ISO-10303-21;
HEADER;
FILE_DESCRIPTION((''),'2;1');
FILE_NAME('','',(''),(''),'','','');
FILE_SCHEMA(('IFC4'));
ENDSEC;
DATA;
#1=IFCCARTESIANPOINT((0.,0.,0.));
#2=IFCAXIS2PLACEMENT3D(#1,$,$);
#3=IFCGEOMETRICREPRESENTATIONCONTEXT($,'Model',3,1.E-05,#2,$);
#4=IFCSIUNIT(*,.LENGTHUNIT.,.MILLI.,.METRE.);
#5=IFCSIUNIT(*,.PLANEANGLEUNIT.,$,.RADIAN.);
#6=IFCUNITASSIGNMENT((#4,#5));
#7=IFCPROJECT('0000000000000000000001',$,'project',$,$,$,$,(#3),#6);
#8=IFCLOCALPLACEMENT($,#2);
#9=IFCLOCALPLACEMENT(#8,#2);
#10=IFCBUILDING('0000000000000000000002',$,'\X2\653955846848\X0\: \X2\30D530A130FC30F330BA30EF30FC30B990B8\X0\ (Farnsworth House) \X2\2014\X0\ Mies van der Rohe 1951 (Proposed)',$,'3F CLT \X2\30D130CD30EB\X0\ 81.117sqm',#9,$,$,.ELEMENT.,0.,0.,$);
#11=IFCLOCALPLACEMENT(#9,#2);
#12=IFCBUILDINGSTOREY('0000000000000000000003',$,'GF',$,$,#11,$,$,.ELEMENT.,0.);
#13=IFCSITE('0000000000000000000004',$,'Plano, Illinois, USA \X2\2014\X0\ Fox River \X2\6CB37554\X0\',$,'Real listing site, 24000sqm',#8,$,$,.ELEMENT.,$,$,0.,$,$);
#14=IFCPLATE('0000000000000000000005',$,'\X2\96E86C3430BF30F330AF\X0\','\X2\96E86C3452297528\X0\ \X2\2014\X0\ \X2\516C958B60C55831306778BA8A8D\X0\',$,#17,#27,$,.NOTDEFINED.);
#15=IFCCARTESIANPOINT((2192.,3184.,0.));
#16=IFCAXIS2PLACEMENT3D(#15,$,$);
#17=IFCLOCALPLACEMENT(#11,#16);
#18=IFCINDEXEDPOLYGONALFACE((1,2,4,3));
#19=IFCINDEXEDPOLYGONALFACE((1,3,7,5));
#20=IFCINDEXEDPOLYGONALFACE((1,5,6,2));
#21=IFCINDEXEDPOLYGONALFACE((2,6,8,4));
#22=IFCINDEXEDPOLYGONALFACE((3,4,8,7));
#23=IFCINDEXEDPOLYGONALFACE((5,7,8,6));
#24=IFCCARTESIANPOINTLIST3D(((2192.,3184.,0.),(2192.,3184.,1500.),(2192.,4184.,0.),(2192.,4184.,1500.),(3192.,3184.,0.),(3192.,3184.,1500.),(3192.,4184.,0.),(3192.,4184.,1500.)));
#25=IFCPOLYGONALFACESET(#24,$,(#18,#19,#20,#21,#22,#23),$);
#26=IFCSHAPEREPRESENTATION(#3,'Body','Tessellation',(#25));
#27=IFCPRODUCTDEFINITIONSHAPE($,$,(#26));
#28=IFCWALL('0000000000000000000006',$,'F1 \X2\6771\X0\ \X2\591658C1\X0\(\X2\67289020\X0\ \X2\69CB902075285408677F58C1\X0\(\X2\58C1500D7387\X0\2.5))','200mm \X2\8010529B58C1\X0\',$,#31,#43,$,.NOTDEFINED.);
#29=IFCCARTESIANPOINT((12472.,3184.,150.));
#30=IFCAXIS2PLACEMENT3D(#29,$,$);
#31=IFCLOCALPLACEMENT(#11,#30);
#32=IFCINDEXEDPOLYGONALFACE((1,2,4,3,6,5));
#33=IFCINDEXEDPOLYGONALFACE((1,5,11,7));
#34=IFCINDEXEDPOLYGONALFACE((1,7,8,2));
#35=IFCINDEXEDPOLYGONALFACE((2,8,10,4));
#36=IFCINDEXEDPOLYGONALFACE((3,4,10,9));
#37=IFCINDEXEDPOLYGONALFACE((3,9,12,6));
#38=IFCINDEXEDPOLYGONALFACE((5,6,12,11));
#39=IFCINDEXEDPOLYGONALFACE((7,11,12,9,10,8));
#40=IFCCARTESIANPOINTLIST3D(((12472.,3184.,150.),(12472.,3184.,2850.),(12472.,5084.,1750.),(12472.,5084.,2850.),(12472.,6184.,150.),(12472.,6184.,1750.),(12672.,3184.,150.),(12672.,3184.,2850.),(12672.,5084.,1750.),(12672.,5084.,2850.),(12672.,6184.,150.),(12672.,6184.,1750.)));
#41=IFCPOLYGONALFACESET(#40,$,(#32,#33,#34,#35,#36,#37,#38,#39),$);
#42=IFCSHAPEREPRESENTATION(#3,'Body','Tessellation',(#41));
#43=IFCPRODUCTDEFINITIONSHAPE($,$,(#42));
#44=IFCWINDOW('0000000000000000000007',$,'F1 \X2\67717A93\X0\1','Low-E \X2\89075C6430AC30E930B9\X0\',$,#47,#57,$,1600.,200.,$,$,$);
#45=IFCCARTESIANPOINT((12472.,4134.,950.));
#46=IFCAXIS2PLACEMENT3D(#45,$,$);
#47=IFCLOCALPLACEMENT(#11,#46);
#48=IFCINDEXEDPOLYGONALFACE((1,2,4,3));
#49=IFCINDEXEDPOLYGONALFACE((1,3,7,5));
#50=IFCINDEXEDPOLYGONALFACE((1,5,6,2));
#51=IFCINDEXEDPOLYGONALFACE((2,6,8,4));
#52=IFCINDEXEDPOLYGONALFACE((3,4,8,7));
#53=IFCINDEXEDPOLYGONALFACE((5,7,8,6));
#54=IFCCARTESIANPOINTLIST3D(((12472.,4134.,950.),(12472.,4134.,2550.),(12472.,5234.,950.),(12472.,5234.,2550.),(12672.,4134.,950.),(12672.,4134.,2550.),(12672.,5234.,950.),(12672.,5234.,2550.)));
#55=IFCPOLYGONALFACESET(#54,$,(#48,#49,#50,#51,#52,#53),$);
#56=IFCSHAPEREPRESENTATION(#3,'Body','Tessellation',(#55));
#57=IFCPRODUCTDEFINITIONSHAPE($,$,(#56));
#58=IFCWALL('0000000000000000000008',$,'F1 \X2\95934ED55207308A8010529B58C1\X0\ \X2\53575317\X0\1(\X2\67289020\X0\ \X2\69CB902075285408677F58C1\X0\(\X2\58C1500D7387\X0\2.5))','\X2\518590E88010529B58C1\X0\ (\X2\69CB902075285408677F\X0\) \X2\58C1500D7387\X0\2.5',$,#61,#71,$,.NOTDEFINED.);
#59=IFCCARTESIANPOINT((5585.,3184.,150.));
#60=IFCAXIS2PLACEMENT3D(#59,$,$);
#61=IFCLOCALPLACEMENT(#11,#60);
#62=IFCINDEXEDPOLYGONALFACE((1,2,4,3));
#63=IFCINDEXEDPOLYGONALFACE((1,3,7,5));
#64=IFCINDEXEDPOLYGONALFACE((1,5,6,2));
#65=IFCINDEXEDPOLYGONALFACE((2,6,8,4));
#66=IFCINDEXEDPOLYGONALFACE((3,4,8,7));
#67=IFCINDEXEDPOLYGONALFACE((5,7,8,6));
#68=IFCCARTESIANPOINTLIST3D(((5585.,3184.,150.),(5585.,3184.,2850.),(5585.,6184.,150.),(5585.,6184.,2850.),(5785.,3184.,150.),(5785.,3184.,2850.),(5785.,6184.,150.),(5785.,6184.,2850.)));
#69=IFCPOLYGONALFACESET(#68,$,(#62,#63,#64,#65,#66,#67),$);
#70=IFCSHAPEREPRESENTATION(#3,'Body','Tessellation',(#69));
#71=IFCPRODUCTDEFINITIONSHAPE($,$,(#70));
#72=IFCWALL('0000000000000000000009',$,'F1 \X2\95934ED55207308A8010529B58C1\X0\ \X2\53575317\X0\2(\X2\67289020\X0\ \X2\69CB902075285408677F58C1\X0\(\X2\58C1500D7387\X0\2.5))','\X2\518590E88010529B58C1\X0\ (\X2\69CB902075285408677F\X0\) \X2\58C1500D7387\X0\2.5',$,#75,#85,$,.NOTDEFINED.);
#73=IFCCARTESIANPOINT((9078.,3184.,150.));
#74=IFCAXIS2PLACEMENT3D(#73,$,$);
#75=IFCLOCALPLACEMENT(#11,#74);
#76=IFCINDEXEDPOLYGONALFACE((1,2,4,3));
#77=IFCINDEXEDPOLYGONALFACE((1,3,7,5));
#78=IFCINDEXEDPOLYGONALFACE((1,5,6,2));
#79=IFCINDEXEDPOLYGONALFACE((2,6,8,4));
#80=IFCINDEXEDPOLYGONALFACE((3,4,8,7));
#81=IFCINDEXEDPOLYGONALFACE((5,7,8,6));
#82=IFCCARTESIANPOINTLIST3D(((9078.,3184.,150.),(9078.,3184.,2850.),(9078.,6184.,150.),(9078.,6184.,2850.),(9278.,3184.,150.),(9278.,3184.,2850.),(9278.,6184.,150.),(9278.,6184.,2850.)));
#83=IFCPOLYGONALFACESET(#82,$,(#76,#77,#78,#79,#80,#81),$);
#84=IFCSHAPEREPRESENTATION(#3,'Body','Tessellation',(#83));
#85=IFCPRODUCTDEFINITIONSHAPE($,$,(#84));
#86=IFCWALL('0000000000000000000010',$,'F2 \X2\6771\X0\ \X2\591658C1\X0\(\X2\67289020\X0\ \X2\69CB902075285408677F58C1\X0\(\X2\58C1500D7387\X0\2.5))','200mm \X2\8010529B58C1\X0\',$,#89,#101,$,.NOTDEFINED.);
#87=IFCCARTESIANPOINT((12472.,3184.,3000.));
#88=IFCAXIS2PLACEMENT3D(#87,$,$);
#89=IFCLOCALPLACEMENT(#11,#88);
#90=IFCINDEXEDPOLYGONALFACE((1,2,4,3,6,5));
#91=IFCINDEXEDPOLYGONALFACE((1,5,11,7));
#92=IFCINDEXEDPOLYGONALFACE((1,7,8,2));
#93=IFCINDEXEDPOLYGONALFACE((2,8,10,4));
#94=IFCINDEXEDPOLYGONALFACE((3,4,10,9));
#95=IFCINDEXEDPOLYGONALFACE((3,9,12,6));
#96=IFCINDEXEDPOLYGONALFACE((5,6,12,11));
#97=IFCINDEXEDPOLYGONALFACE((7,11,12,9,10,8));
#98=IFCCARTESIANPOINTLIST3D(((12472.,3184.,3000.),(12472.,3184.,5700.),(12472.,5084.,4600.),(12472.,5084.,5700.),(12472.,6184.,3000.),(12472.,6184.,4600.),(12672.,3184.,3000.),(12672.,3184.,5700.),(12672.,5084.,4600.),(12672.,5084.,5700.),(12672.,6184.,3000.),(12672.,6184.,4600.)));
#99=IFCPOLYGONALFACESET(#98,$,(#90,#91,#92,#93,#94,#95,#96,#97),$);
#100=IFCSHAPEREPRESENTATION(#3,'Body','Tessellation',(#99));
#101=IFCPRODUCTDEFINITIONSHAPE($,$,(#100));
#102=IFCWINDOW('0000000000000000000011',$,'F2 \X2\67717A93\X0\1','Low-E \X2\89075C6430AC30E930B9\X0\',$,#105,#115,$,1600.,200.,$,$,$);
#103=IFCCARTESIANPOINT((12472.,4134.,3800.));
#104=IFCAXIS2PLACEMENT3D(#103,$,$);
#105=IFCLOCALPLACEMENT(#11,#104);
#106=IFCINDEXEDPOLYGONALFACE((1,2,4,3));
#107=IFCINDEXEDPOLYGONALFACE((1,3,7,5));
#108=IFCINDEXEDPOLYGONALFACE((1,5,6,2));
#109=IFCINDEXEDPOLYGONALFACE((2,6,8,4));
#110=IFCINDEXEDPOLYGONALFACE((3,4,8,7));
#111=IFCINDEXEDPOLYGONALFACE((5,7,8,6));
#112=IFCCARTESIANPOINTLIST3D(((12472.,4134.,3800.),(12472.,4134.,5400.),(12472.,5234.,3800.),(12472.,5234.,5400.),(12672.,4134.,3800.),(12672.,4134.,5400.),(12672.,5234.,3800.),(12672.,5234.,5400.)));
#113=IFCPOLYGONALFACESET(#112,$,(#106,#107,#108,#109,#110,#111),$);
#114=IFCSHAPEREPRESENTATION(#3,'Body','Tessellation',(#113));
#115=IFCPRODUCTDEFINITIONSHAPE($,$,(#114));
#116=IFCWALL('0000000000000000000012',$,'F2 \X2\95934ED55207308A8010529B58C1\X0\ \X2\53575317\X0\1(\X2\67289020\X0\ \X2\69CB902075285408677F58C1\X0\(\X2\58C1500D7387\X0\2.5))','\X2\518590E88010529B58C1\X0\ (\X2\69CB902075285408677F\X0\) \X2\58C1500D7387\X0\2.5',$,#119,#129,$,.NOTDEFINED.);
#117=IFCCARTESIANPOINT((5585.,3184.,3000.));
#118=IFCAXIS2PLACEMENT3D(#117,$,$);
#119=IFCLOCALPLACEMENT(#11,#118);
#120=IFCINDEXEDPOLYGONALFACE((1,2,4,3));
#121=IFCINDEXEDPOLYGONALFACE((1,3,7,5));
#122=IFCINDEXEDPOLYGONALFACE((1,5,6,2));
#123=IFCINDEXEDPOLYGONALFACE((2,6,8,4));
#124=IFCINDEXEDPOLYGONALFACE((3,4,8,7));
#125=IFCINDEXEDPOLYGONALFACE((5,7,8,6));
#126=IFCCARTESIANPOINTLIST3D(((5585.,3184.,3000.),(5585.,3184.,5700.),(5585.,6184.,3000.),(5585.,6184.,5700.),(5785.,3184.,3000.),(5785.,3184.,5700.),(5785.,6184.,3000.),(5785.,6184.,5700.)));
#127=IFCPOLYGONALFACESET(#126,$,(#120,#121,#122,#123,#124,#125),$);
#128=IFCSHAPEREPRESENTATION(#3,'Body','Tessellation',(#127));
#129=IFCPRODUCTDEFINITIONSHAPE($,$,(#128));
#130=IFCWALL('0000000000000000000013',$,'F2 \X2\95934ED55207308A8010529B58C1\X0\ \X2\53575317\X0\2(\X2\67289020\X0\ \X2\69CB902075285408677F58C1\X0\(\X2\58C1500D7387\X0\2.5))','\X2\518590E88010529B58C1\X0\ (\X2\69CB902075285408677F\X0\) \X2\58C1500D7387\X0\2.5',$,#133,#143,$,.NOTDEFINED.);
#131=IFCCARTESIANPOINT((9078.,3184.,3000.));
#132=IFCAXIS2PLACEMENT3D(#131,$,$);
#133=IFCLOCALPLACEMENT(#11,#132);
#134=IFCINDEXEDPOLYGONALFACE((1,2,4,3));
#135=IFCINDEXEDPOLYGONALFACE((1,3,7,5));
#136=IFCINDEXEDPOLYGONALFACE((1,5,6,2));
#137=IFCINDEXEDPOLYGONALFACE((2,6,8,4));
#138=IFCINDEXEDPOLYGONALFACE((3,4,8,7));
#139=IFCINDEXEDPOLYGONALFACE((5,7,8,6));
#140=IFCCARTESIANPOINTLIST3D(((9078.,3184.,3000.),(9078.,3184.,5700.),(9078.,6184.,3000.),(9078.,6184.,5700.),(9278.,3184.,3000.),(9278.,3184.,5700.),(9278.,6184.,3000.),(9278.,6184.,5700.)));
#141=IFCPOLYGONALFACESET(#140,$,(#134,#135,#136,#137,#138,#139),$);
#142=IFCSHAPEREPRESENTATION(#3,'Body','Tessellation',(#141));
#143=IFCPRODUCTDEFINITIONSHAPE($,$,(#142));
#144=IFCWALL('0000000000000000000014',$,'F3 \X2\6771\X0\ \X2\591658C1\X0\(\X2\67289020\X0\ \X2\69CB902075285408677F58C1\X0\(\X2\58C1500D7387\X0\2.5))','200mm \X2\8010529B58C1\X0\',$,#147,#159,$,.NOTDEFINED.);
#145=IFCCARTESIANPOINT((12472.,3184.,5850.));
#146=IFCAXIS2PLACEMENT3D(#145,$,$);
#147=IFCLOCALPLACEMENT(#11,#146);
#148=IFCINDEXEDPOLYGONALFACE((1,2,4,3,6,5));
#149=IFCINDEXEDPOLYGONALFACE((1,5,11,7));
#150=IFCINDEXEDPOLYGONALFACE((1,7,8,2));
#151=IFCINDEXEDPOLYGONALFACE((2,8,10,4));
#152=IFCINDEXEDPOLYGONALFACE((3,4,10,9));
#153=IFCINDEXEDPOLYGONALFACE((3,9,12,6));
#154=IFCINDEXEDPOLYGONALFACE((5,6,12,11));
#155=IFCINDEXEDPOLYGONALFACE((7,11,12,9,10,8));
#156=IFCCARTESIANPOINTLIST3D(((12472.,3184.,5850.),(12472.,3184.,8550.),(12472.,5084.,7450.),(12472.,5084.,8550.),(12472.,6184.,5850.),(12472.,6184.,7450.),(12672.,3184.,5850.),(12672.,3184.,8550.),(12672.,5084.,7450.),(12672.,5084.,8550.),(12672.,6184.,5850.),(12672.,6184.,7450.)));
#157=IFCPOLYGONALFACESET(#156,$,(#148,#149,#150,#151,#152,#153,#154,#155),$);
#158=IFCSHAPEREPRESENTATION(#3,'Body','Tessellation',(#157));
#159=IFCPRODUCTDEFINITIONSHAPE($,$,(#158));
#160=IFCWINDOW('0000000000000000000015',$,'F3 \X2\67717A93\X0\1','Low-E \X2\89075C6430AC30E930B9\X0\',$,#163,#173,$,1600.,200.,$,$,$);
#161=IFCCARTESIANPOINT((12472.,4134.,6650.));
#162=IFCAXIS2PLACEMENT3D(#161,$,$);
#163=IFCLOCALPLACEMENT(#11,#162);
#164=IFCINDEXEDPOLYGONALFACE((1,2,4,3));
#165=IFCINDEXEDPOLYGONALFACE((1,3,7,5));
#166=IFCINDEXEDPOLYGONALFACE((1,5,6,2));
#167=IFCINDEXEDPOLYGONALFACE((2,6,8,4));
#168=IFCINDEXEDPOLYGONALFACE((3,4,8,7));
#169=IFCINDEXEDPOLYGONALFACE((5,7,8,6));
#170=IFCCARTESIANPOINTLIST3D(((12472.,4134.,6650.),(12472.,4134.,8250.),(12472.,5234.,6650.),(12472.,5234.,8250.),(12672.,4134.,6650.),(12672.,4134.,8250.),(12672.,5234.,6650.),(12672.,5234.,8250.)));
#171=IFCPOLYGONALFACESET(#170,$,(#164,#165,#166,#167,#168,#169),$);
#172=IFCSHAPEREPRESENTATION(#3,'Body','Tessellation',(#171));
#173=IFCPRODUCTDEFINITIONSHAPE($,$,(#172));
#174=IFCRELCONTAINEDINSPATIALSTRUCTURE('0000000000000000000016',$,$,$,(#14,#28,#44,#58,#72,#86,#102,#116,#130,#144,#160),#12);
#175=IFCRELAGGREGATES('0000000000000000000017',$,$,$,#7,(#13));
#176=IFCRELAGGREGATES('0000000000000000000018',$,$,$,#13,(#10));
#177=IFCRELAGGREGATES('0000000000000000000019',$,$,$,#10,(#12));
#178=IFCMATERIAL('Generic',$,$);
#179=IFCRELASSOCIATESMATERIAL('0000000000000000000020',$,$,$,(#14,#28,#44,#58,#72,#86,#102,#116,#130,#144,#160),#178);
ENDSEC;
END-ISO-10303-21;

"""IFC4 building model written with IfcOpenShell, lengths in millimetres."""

from ifc_helpers import new_model, si_unit, frame, frame_2d, origin, place, context, project, spatial, rectangle, extrude, material, element, fill, save


model = new_model("IFC4")

# Units and contexts
model_context = context("Model", 3, precision=1e-05, world=origin())
ifc_project = project(units=[si_unit("LENGTHUNIT", "METRE", prefix="MILLI"), si_unit("PLANEANGLEUNIT", "RADIAN")], contexts=[model_context])

# Site, building, storey
site_placement = place(None, origin())
site = spatial("IfcSite", under=ifc_project, at=site_placement, Name="Plano, Illinois, USA — Fox River 河畔", ObjectType="Real listing site, 24000sqm", CompositionType="ELEMENT", RefElevation=0.0)
building_placement = place(site_placement, origin())
building = spatial("IfcBuilding", under=site, at=building_placement, Name="改善案: ファーンズワース邸 (Farnsworth House) — Mies van der Rohe 1951 (Proposed)", ObjectType="3F CLT パネル 81.117sqm", CompositionType="ELEMENT", ElevationOfRefHeight=0.0, ElevationOfTerrain=0.0)
storey_placement = place(building_placement, origin())
storey = spatial("IfcBuildingStorey", under=building, at=storey_placement, Name="GF", CompositionType="ELEMENT", Elevation=0.0)

# Plate
ifc_material_1 = material(Name="Generic")
plate_placement = place(storey_placement, frame((2192.0, 3184.0, 0.0)))
element("IfcPlate", 1, at=plate_placement, inside=storey, material=ifc_material_1, Name="雨水タンク", Description="雨水利用 — 公開情報で確認", PredefinedType="NOTDEFINED", context=model_context, shape_type="SweptSolid", body=[
    extrude(rectangle(XDim=1000.0, YDim=1000.0, at=frame_2d((500.0, 500.0))), frame((2192.0, 3184.0, 0.0)), (0.0, 0.0, 1.0), 1500.0),
])

# Wall, opening, window
wall_1_placement = place(storey_placement, frame((12472.0, 3184.0, 150.0)))
wall_1 = element("IfcWall", 2, at=wall_1_placement, inside=storey, material=ifc_material_1, Name="F1 東 外壁(木造 構造用合板壁(壁倍率2.5))", Description="200mm 耐力壁", PredefinedType="NOTDEFINED", context=model_context, shape_type="SweptSolid", body=[
    extrude(rectangle(XDim=200.0, YDim=3000.0, at=frame_2d((100.0, 1500.0))), frame((12472.0, 3184.0, 150.0)), (0.0, 0.0, 1.0), 2700.0),
])
opening_1_placement = place(storey_placement, frame((12472.0, 4134.0, 950.0)))
opening_1 = element("IfcOpeningElement", 3, at=opening_1_placement, cuts=wall_1, PredefinedType="NOTDEFINED", context=model_context, shape_type="SweptSolid", body=[
    extrude(rectangle(XDim=200.0, YDim=1100.0, at=frame_2d((100.0, 550.0))), frame((12472.0, 4134.0, 950.0)), (0.0, 0.0, 1.0), 1600.0),
])
window_1_placement = place(storey_placement, frame((12472.0, 4134.0, 950.0)))
window_1 = element("IfcWindow", 4, at=window_1_placement, inside=storey, material=ifc_material_1, Name="F1 東窓1", Description="Low-E 複層ガラス", OverallHeight=1600.0, OverallWidth=200.0, context=model_context, shape_type="SweptSolid", body=[
    extrude(rectangle(XDim=200.0, YDim=1100.0, at=frame_2d((100.0, 550.0))), frame((12472.0, 4134.0, 950.0)), (0.0, 0.0, 1.0), 1600.0),
])
fill(opening_1, window_1)

# Walls
wall_2_placement = place(storey_placement, frame((5585.0, 3184.0, 150.0)))
element("IfcWall", 5, at=wall_2_placement, inside=storey, material=ifc_material_1, Name="F1 間仕切り耐力壁 南北1(木造 構造用合板壁(壁倍率2.5))", Description="内部耐力壁 (構造用合板) 壁倍率2.5", PredefinedType="NOTDEFINED", context=model_context, shape_type="SweptSolid", body=[
    extrude(rectangle(XDim=200.0, YDim=3000.0, at=frame_2d((100.0, 1500.0))), frame((5585.0, 3184.0, 150.0)), (0.0, 0.0, 1.0), 2700.0),
])
wall_3_placement = place(storey_placement, frame((9078.0, 3184.0, 150.0)))
element("IfcWall", 6, at=wall_3_placement, inside=storey, material=ifc_material_1, Name="F1 間仕切り耐力壁 南北2(木造 構造用合板壁(壁倍率2.5))", Description="内部耐力壁 (構造用合板) 壁倍率2.5", PredefinedType="NOTDEFINED", context=model_context, shape_type="SweptSolid", body=[
    extrude(rectangle(XDim=200.0, YDim=3000.0, at=frame_2d((100.0, 1500.0))), frame((9078.0, 3184.0, 150.0)), (0.0, 0.0, 1.0), 2700.0),
])

# Wall, opening, window
wall_4_placement = place(storey_placement, frame((12472.0, 3184.0, 3000.0)))
wall_4 = element("IfcWall", 7, at=wall_4_placement, inside=storey, material=ifc_material_1, Name="F2 東 外壁(木造 構造用合板壁(壁倍率2.5))", Description="200mm 耐力壁", PredefinedType="NOTDEFINED", context=model_context, shape_type="SweptSolid", body=[
    extrude(rectangle(XDim=200.0, YDim=3000.0, at=frame_2d((100.0, 1500.0))), frame((12472.0, 3184.0, 3000.0)), (0.0, 0.0, 1.0), 2700.0),
])
opening_2_placement = place(storey_placement, frame((12472.0, 4134.0, 3800.0)))
opening_2 = element("IfcOpeningElement", 8, at=opening_2_placement, cuts=wall_4, PredefinedType="NOTDEFINED", context=model_context, shape_type="SweptSolid", body=[
    extrude(rectangle(XDim=200.0, YDim=1100.0, at=frame_2d((100.0, 550.0))), frame((12472.0, 4134.0, 3800.0)), (0.0, 0.0, 1.0), 1600.0),
])
window_2_placement = place(storey_placement, frame((12472.0, 4134.0, 3800.0)))
window_2 = element("IfcWindow", 9, at=window_2_placement, inside=storey, material=ifc_material_1, Name="F2 東窓1", Description="Low-E 複層ガラス", OverallHeight=1600.0, OverallWidth=200.0, context=model_context, shape_type="SweptSolid", body=[
    extrude(rectangle(XDim=200.0, YDim=1100.0, at=frame_2d((100.0, 550.0))), frame((12472.0, 4134.0, 3800.0)), (0.0, 0.0, 1.0), 1600.0),
])
fill(opening_2, window_2)

# Walls
wall_5_placement = place(storey_placement, frame((5585.0, 3184.0, 3000.0)))
element("IfcWall", 10, at=wall_5_placement, inside=storey, material=ifc_material_1, Name="F2 間仕切り耐力壁 南北1(木造 構造用合板壁(壁倍率2.5))", Description="内部耐力壁 (構造用合板) 壁倍率2.5", PredefinedType="NOTDEFINED", context=model_context, shape_type="SweptSolid", body=[
    extrude(rectangle(XDim=200.0, YDim=3000.0, at=frame_2d((100.0, 1500.0))), frame((5585.0, 3184.0, 3000.0)), (0.0, 0.0, 1.0), 2700.0),
])
wall_6_placement = place(storey_placement, frame((9078.0, 3184.0, 3000.0)))
element("IfcWall", 11, at=wall_6_placement, inside=storey, material=ifc_material_1, Name="F2 間仕切り耐力壁 南北2(木造 構造用合板壁(壁倍率2.5))", Description="内部耐力壁 (構造用合板) 壁倍率2.5", PredefinedType="NOTDEFINED", context=model_context, shape_type="SweptSolid", body=[
    extrude(rectangle(XDim=200.0, YDim=3000.0, at=frame_2d((100.0, 1500.0))), frame((9078.0, 3184.0, 3000.0)), (0.0, 0.0, 1.0), 2700.0),
])

# Wall, opening, window
wall_7_placement = place(storey_placement, frame((12472.0, 3184.0, 5850.0)))
wall_7 = element("IfcWall", 12, at=wall_7_placement, inside=storey, material=ifc_material_1, Name="F3 東 外壁(木造 構造用合板壁(壁倍率2.5))", Description="200mm 耐力壁", PredefinedType="NOTDEFINED", context=model_context, shape_type="SweptSolid", body=[
    extrude(rectangle(XDim=200.0, YDim=3000.0, at=frame_2d((100.0, 1500.0))), frame((12472.0, 3184.0, 5850.0)), (0.0, 0.0, 1.0), 2700.0),
])
opening_3_placement = place(storey_placement, frame((12472.0, 4134.0, 6650.0)))
opening_3 = element("IfcOpeningElement", 13, at=opening_3_placement, cuts=wall_7, PredefinedType="NOTDEFINED", context=model_context, shape_type="SweptSolid", body=[
    extrude(rectangle(XDim=200.0, YDim=1100.0, at=frame_2d((100.0, 550.0))), frame((12472.0, 4134.0, 6650.0)), (0.0, 0.0, 1.0), 1600.0),
])
window_3_placement = place(storey_placement, frame((12472.0, 4134.0, 6650.0)))
window_3 = element("IfcWindow", 14, at=window_3_placement, inside=storey, material=ifc_material_1, Name="F3 東窓1", Description="Low-E 複層ガラス", OverallHeight=1600.0, OverallWidth=200.0, context=model_context, shape_type="SweptSolid", body=[
    extrude(rectangle(XDim=200.0, YDim=1100.0, at=frame_2d((100.0, 550.0))), frame((12472.0, 4134.0, 6650.0)), (0.0, 0.0, 1.0), 1600.0),
])
fill(opening_3, window_3)

save(model, "model.ifc")
